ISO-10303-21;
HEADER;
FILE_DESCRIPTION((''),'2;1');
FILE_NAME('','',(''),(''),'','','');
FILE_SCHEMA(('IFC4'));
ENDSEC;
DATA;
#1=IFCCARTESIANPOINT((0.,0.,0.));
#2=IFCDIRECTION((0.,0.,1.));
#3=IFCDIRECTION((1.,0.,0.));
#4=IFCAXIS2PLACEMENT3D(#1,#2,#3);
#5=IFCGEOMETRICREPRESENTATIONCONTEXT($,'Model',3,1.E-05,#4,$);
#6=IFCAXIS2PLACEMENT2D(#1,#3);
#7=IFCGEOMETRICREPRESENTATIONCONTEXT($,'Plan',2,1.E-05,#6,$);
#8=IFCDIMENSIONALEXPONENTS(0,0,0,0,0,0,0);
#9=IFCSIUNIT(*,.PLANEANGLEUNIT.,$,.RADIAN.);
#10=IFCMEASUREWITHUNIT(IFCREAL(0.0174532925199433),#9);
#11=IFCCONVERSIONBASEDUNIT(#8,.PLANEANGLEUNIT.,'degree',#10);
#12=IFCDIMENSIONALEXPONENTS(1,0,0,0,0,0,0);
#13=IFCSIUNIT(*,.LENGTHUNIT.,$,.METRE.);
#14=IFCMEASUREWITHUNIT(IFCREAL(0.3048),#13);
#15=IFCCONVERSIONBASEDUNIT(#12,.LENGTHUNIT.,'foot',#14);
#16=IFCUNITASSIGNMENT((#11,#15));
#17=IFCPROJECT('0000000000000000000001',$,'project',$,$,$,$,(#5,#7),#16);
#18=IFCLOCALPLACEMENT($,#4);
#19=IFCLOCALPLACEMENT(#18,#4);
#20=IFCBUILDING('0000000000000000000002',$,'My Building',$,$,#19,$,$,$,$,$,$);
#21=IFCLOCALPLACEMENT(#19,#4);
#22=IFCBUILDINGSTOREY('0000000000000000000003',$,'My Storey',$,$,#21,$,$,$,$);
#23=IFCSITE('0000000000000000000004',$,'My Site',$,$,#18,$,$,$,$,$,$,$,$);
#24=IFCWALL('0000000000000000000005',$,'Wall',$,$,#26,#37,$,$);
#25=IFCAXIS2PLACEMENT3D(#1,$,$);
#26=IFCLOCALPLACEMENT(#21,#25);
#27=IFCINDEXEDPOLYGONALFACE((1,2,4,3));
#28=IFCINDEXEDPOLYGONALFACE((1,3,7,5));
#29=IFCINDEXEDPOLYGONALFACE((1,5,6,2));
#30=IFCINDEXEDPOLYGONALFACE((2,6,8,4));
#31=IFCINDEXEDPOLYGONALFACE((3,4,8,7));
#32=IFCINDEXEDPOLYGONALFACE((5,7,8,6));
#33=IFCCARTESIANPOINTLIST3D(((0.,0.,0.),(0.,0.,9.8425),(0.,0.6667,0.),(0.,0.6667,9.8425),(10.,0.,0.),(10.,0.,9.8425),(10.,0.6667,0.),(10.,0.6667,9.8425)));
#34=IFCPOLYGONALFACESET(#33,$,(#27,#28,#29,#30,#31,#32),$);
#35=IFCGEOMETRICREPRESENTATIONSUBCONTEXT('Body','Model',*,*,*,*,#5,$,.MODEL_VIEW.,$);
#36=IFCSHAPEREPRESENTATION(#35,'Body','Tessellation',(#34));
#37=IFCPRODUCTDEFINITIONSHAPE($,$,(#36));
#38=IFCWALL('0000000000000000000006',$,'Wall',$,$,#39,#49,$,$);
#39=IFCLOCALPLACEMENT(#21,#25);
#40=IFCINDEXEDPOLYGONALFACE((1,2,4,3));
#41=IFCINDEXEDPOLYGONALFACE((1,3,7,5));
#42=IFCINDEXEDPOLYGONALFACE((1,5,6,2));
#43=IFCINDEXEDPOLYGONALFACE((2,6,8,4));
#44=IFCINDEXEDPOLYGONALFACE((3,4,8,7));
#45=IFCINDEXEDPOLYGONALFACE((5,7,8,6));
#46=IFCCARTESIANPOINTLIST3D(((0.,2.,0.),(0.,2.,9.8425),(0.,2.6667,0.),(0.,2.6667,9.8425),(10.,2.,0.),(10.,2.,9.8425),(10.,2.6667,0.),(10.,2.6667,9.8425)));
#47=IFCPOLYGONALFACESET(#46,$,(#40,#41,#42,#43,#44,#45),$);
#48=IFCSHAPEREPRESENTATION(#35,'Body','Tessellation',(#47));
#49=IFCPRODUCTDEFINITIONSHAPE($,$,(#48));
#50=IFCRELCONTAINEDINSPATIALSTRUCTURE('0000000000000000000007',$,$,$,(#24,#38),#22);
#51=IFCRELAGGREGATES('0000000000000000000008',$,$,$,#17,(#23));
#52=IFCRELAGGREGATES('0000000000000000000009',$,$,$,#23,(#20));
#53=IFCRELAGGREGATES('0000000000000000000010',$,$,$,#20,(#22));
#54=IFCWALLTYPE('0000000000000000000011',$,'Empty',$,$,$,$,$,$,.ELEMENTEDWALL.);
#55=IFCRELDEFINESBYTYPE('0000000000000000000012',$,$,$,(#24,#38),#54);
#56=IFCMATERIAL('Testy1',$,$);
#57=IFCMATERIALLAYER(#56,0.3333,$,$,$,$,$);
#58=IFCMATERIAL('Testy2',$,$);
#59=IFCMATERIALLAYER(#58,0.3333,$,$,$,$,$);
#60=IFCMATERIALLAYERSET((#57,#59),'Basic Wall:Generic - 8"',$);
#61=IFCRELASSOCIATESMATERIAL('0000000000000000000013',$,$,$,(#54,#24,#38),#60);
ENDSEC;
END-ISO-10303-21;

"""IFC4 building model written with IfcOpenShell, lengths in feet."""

from ifc_helpers import new_model, entity, si_unit, converted_unit, frame, frame_2d, origin_with_axes, place, context, subcontext, project, spatial, polyline, outline, extrude, material, layer, layer_set, layer_usage, type_object, element, save


model = new_model("IFC4")

# Units and contexts
model_context = context("Model", 3, precision=1e-05, world=origin_with_axes())
plan_context = context("Plan", 2, precision=1e-05, world=frame_2d((0.0, 0.0, 0.0), x_axis=(1.0, 0.0, 0.0)))
body_context = subcontext(model_context, "Body", "Model", "MODEL_VIEW")
ifc_project = project(units=[converted_unit("PLANEANGLEUNIT", "degree", entity("IfcReal", 0.0174532925199433), si_unit("PLANEANGLEUNIT", "RADIAN"), dimensions=[0, 0, 0, 0, 0, 0, 0]), converted_unit("LENGTHUNIT", "foot", entity("IfcReal", 0.3048), si_unit("LENGTHUNIT", "METRE"), dimensions=[1, 0, 0, 0, 0, 0, 0])], contexts=[model_context, plan_context])

# Site, building, storey
site_placement = place(None, origin_with_axes())
site = spatial("IfcSite", under=ifc_project, at=site_placement, Name="My Site")
building_placement = place(site_placement, origin_with_axes())
building = spatial("IfcBuilding", under=site, at=building_placement, Name="My Building")
storey_placement = place(building_placement, origin_with_axes())
storey = spatial("IfcBuildingStorey", under=building, at=storey_placement, Name="My Storey")

# Walls
ifc_material_1 = material(Name="Testy1")
ifc_layer_1 = layer(ifc_material_1, 0.3333)
ifc_material_2 = material(Name="Testy2")
ifc_layer_2 = layer(ifc_material_2, 0.3333)
ifc_layer_set = layer_set([ifc_layer_1, ifc_layer_2], Name="Basic Wall:Generic - 8\"")
ifc_layer_usage_1 = layer_usage(ifc_layer_set, "AXIS2", "POSITIVE", 0.0)
wall_type = type_object("IfcWallType", Name="Empty", PredefinedType="ELEMENTEDWALL", material=ifc_layer_set)
wall_1_placement = place(storey_placement, origin_with_axes())
element("IfcWall", 1, at=wall_1_placement, inside=storey, type_object=wall_type, material=ifc_layer_usage_1, Name="Wall", context=body_context, shape_type="SweptSolid", body=[
    extrude(outline(polyline([(-0.3333, -5.0), (0.3333, -5.0), (0.3333, 5.0), (-0.3333, 5.0), (-0.3333, -5.0)])), frame((5.0, 0.3333, 0.0), z_axis=(0.0, 0.0, -1.0), x_axis=(0.0, -1.0, 0.0)), (0.0, 0.0, -1.0), 9.8425),
])
ifc_layer_usage_2 = layer_usage(ifc_layer_set, "AXIS2", "POSITIVE", 0.0)
wall_2_placement = place(storey_placement, frame((0.0, 2.0, 0.0), z_axis=(0.0, 0.0, 1.0), x_axis=(1.0, 0.0, 0.0)))
element("IfcWall", 2, at=wall_2_placement, inside=storey, type_object=wall_type, material=ifc_layer_usage_2, Name="Wall", context=body_context, shape_type="SweptSolid", body=[
    extrude(outline(polyline([(-0.3333, -5.0), (0.3333, -5.0), (0.3333, 5.0), (-0.3333, 5.0), (-0.3333, -5.0)])), frame((5.0, 0.3333, 0.0), z_axis=(0.0, 0.0, -1.0), x_axis=(0.0, -1.0, 0.0)), (0.0, 0.0, -1.0), 9.8425),
])

save(model, "model.ifc")
